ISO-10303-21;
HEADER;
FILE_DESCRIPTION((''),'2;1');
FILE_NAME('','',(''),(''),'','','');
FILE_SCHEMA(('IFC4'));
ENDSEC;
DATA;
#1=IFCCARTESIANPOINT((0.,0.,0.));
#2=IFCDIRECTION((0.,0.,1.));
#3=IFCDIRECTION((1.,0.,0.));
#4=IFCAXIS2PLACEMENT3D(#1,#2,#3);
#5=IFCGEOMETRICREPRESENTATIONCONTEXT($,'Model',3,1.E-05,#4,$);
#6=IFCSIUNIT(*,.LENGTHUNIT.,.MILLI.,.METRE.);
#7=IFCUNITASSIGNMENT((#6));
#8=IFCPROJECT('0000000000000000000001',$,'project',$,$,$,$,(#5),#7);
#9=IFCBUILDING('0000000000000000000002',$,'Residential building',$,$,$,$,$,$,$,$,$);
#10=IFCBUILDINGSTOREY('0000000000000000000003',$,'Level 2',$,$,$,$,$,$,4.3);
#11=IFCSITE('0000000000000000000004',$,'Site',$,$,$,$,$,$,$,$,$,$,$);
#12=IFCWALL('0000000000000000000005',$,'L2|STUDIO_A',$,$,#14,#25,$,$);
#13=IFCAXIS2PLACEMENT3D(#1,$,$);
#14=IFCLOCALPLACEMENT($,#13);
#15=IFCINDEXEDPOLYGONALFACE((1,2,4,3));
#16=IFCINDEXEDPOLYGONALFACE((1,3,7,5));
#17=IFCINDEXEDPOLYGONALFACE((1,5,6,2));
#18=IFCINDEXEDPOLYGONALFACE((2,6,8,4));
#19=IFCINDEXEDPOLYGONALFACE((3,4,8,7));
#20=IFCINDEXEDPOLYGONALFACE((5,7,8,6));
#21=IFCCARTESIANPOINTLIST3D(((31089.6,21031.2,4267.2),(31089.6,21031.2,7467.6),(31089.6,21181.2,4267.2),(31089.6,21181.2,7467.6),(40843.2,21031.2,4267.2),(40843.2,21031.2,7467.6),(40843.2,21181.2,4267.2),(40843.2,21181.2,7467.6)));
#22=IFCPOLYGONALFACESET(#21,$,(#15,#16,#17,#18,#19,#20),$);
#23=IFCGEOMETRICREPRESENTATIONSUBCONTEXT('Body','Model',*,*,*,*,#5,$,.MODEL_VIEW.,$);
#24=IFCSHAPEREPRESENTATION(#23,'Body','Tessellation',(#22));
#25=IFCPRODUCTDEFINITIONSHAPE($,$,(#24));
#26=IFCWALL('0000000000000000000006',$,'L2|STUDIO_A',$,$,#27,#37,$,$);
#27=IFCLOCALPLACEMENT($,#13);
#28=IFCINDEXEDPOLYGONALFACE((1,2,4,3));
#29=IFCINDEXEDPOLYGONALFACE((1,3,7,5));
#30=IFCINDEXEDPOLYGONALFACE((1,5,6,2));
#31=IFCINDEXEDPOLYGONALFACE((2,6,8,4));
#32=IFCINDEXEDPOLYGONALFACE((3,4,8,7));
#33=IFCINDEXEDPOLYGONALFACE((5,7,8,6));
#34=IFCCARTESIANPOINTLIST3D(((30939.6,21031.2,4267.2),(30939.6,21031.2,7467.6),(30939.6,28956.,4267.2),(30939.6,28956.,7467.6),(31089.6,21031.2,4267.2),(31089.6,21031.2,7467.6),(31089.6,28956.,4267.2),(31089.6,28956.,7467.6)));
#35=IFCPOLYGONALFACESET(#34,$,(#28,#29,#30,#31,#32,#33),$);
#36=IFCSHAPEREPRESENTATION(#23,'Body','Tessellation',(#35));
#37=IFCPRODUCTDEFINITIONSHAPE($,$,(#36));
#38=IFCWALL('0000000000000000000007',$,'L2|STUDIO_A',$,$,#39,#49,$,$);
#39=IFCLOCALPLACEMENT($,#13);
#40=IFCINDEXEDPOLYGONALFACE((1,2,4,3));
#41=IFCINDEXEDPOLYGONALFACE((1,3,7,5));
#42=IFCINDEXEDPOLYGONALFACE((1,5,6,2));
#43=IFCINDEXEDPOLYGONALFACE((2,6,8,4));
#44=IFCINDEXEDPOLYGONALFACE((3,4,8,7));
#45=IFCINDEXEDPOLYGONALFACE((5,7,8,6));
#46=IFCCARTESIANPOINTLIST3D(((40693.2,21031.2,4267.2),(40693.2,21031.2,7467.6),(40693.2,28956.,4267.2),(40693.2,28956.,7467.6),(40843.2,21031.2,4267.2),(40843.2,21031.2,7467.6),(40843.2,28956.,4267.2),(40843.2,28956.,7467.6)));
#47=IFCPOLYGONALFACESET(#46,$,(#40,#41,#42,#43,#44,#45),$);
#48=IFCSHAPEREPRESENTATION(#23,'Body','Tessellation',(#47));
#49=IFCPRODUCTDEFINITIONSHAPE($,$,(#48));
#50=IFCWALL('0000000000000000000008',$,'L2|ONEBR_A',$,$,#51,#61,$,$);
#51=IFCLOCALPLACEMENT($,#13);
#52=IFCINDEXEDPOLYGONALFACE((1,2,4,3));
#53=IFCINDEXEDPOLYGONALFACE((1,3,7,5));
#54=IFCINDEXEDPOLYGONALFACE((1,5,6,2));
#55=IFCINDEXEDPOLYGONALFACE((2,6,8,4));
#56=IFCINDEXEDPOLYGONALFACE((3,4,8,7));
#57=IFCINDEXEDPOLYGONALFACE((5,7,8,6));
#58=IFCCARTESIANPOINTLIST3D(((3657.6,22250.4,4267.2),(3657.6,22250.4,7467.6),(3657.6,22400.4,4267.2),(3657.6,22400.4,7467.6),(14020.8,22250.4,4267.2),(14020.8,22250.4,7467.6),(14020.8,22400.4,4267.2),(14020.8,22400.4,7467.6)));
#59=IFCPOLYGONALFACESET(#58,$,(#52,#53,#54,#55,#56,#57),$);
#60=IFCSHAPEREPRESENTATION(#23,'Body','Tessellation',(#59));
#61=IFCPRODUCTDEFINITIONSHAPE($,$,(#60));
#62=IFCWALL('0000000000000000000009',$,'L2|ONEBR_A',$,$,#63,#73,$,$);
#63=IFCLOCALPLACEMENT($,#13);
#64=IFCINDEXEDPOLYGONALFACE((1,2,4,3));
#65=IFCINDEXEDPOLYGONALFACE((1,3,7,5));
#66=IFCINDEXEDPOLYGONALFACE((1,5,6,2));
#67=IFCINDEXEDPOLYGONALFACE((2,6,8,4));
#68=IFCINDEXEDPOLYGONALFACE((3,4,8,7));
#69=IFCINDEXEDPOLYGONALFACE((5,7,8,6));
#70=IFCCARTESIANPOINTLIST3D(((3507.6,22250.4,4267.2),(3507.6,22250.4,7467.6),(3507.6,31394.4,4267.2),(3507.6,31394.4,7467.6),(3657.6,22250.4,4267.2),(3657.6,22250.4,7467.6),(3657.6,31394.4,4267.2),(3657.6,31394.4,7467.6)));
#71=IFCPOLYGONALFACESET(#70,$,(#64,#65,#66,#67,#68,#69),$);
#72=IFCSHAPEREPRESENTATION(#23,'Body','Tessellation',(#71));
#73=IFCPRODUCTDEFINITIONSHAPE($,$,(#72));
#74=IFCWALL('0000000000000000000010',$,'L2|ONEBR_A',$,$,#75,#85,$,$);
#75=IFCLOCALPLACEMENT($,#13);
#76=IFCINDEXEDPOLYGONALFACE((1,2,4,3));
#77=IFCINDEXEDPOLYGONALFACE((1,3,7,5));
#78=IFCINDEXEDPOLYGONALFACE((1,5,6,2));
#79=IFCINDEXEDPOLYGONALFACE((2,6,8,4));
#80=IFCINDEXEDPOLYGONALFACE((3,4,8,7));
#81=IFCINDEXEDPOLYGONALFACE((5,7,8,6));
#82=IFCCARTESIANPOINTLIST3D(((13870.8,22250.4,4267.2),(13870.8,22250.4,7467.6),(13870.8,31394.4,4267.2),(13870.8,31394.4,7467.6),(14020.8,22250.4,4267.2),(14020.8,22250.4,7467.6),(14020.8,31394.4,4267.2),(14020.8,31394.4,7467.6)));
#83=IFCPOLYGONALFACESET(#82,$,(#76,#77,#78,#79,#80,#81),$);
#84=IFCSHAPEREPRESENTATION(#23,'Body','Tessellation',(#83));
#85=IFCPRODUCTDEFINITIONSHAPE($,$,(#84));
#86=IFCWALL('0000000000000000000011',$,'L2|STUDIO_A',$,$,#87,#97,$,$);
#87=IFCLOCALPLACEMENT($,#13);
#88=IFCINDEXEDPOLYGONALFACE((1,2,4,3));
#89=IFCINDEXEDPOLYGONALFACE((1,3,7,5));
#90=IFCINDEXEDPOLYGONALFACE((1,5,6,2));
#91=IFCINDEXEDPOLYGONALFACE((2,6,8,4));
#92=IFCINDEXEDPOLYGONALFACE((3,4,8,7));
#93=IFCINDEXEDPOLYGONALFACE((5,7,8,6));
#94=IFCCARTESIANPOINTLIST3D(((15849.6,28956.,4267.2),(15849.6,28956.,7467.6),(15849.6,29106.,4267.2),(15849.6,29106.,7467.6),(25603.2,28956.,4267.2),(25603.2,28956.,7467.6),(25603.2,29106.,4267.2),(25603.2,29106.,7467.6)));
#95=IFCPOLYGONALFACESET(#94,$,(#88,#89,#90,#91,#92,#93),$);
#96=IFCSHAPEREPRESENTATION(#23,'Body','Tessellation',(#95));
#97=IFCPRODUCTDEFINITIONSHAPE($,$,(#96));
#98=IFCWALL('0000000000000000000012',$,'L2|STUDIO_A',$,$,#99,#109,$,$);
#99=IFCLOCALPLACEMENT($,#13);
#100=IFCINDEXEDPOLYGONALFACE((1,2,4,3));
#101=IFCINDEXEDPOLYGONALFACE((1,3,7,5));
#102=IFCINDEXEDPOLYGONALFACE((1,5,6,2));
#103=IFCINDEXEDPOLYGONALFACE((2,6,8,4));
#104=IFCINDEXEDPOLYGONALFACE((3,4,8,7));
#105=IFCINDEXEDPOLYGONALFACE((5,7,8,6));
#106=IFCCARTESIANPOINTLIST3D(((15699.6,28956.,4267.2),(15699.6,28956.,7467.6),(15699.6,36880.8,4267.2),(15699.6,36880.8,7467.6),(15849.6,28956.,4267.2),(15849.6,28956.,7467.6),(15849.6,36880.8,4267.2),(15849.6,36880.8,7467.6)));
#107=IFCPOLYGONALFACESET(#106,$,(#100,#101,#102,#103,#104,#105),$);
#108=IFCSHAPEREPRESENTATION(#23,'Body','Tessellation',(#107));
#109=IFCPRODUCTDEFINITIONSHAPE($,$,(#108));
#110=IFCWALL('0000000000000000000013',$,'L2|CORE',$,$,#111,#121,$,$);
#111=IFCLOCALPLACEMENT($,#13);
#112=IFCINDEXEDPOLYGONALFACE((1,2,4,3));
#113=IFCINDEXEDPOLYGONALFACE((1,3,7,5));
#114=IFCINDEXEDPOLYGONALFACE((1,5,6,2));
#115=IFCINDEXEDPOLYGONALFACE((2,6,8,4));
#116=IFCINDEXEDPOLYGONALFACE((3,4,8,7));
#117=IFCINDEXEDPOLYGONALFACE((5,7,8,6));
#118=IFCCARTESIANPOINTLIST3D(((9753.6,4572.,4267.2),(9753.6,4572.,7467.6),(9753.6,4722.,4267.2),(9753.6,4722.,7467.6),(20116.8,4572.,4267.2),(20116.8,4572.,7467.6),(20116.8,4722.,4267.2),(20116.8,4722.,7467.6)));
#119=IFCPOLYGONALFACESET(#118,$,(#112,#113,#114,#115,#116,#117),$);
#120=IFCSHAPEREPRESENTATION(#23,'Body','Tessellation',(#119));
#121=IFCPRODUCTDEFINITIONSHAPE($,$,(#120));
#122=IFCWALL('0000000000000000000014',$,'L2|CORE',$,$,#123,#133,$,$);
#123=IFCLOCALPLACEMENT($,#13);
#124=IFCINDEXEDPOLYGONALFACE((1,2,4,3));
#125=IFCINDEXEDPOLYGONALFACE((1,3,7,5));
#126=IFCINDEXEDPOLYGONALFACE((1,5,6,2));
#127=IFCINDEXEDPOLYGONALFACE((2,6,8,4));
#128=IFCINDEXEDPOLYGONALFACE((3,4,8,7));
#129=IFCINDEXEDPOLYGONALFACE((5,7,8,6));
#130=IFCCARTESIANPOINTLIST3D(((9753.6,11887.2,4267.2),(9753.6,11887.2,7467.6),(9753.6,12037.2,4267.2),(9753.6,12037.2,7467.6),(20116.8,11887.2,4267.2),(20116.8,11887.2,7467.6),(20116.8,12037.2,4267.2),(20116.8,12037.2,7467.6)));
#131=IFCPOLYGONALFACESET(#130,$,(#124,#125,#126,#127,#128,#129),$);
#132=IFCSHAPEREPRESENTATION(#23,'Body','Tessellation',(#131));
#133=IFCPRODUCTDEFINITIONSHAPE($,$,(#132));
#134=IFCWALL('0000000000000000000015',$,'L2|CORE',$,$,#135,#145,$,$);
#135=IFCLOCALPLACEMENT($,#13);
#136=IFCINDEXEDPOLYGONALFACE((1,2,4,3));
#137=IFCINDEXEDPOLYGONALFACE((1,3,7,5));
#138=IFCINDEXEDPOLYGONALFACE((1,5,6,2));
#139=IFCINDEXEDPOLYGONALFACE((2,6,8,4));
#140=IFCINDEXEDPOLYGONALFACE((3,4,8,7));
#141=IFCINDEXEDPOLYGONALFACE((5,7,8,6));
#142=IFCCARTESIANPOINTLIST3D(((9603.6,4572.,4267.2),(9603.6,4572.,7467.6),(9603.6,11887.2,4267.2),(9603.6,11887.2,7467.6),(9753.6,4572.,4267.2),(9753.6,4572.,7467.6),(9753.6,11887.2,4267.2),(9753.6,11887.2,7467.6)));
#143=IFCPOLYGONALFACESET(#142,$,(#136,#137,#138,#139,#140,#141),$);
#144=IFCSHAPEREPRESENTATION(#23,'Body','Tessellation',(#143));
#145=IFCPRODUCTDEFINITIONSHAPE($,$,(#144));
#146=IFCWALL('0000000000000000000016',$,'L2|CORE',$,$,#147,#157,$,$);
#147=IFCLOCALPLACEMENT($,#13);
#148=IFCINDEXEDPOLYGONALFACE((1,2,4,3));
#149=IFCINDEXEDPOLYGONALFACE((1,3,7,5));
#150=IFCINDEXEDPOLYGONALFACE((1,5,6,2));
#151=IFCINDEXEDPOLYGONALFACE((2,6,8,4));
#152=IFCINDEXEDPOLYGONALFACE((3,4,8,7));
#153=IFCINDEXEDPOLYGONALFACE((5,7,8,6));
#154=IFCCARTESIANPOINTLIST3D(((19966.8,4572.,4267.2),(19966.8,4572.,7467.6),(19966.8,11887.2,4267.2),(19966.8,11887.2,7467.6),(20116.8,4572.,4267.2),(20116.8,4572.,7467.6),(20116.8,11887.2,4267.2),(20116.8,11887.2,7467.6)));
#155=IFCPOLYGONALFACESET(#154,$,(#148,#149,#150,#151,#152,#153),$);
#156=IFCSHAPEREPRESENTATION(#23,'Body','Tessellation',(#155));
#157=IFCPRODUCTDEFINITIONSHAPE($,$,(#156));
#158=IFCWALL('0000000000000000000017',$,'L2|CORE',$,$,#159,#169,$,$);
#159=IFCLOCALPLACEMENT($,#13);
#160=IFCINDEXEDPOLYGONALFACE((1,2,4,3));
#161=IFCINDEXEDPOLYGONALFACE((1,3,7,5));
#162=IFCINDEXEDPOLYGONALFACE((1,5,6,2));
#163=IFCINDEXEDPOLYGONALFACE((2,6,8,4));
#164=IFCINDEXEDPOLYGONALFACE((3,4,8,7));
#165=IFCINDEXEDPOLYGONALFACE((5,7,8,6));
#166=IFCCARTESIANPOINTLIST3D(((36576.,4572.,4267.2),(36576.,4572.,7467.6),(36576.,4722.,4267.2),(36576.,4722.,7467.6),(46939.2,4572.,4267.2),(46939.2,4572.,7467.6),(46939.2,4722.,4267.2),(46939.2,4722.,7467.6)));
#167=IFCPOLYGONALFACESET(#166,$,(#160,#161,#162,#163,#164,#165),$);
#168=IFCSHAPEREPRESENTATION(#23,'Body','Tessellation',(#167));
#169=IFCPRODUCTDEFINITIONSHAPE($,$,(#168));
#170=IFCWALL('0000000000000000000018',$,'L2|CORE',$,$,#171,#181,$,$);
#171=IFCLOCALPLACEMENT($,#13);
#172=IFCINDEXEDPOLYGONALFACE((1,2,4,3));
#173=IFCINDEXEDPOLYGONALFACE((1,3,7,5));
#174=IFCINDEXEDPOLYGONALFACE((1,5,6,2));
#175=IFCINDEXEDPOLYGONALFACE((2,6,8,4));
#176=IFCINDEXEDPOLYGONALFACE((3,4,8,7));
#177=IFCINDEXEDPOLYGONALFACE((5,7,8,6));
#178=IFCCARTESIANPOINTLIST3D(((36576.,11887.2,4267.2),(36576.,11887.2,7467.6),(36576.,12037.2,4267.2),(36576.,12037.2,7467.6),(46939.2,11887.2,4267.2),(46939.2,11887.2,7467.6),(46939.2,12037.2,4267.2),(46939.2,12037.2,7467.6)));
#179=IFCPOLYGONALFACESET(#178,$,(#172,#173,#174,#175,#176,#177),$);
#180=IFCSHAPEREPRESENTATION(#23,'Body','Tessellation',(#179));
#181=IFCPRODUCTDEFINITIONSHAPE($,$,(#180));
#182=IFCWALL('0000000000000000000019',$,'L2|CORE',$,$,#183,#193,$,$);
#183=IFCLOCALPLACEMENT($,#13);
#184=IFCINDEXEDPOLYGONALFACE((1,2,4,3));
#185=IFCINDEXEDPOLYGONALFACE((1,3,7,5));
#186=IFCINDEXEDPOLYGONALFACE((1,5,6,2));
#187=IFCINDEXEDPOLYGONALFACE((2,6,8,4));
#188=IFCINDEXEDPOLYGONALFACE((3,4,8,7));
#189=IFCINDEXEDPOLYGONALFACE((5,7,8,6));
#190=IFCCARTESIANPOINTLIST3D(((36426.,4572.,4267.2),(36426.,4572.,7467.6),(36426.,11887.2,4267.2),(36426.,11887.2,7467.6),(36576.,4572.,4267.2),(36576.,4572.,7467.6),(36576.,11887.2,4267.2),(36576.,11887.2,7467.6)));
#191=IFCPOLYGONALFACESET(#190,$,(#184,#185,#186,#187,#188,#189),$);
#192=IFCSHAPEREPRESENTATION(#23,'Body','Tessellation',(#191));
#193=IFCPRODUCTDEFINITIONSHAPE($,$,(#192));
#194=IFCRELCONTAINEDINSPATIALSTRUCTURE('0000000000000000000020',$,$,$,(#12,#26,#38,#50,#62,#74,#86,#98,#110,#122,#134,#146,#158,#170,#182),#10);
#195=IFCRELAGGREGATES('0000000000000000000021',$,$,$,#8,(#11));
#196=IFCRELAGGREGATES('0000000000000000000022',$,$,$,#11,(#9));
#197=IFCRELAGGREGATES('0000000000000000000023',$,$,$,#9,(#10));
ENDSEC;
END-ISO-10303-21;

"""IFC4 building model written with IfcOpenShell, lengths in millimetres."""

from ifc_helpers import new_model, si_unit, frame, origin_with_axes, place, context, subcontext, project, spatial, indexed_curve, outline, extrude, element, save


model = new_model("IFC4")

# Units and contexts
model_context = context("Model", 3, precision=1e-05, world=origin_with_axes())
body_context = subcontext(model_context, "Body", "Model", "MODEL_VIEW")
ifc_project = project(units=[si_unit("LENGTHUNIT", "METRE", prefix="MILLI")], contexts=[model_context])

# Site, building, storey
site = spatial("IfcSite", under=ifc_project, Name="Site")
building = spatial("IfcBuilding", under=site, Name="Residential building")
storey = spatial("IfcBuildingStorey", under=building, Name="Level 2", Elevation=4.3)

# Walls
wall_1_placement = place(None, frame((31089.6, 21031.2, 4267.2), z_axis=(0.0, 0.0, 1.0), x_axis=(1.0, 0.0, 0.0)))
element("IfcWall", 1, at=wall_1_placement, inside=storey, Name="L2|STUDIO_A", context=body_context, shape_type="SweptSolid", body=[
    extrude(outline(indexed_curve([(0.0, 0.0), (0.0, 150.0), (9753.6, 150.0), (9753.6, 0.0), (0.0, 0.0)], self_intersect=False)), origin_with_axes(), (0.0, 0.0, 1.0), 3200.4),
])
for number, where, z_axis, x_axis, name in (
    (2, (31089.6, 21031.2, 4267.2), (0.0, 0.0, 1.0), (0.0, 1.0, 0.0), "L2|STUDIO_A"),
    (3, (40843.2, 21031.2, 4267.2), (0.0, 0.0, 1.0), (0.0, 1.0, 0.0), "L2|STUDIO_A"),
):
    element("IfcWall", number, at=place(None, frame(where, z_axis=z_axis, x_axis=x_axis)), inside=storey, Name=name, context=body_context, shape_type="SweptSolid", body=[
        extrude(outline(indexed_curve([(0.0, 0.0), (0.0, 150.0), (7924.8, 150.0), (7924.8, 0.0), (0.0, 0.0)], self_intersect=False)), origin_with_axes(), (0.0, 0.0, 1.0), 3200.4),
    ])
wall_2_placement = place(None, frame((3657.6, 22250.4, 4267.2), z_axis=(0.0, 0.0, 1.0), x_axis=(1.0, 0.0, 0.0)))
element("IfcWall", 4, at=wall_2_placement, inside=storey, Name="L2|ONEBR_A", context=body_context, shape_type="SweptSolid", body=[
    extrude(outline(indexed_curve([(0.0, 0.0), (0.0, 150.0), (10363.2, 150.0), (10363.2, 0.0), (0.0, 0.0)], self_intersect=False)), origin_with_axes(), (0.0, 0.0, 1.0), 3200.4),
])
for number, where, z_axis, x_axis, name in (
    (5, (3657.6, 22250.4, 4267.2), (0.0, 0.0, 1.0), (0.0, 1.0, 0.0), "L2|ONEBR_A"),
    (6, (14020.8, 22250.4, 4267.2), (0.0, 0.0, 1.0), (0.0, 1.0, 0.0), "L2|ONEBR_A"),
):
    element("IfcWall", number, at=place(None, frame(where, z_axis=z_axis, x_axis=x_axis)), inside=storey, Name=name, context=body_context, shape_type="SweptSolid", body=[
        extrude(outline(indexed_curve([(0.0, 0.0), (0.0, 150.0), (9144.0, 150.0), (9144.0, 0.0), (0.0, 0.0)], self_intersect=False)), origin_with_axes(), (0.0, 0.0, 1.0), 3200.4),
    ])
wall_3_placement = place(None, frame((15849.6, 28956.0, 4267.2), z_axis=(0.0, 0.0, 1.0), x_axis=(1.0, 0.0, 0.0)))
element("IfcWall", 7, at=wall_3_placement, inside=storey, Name="L2|STUDIO_A", context=body_context, shape_type="SweptSolid", body=[
    extrude(outline(indexed_curve([(0.0, 0.0), (0.0, 150.0), (9753.6, 150.0), (9753.6, 0.0), (0.0, 0.0)], self_intersect=False)), origin_with_axes(), (0.0, 0.0, 1.0), 3200.4),
])
wall_4_placement = place(None, frame((15849.6, 28956.0, 4267.2), z_axis=(0.0, 0.0, 1.0), x_axis=(0.0, 1.0, 0.0)))
element("IfcWall", 8, at=wall_4_placement, inside=storey, Name="L2|STUDIO_A", context=body_context, shape_type="SweptSolid", body=[
    extrude(outline(indexed_curve([(0.0, 0.0), (0.0, 150.0), (7924.8, 150.0), (7924.8, 0.0), (0.0, 0.0)], self_intersect=False)), origin_with_axes(), (0.0, 0.0, 1.0), 3200.4),
])
for number, where, z_axis, x_axis, name in (
    (9, (9753.6, 4572.0, 4267.2), (0.0, 0.0, 1.0), (1.0, 0.0, 0.0), "L2|CORE"),
    (10, (9753.6, 11887.2, 4267.2), (0.0, 0.0, 1.0), (1.0, 0.0, 0.0), "L2|CORE"),
):
    element("IfcWall", number, at=place(None, frame(where, z_axis=z_axis, x_axis=x_axis)), inside=storey, Name=name, context=body_context, shape_type="SweptSolid", body=[
        extrude(outline(indexed_curve([(0.0, 0.0), (0.0, 150.0), (10363.2, 150.0), (10363.2, 0.0), (0.0, 0.0)], self_intersect=False)), origin_with_axes(), (0.0, 0.0, 1.0), 3200.4),
    ])
for number, where, z_axis, x_axis, name in (
    (11, (9753.6, 4572.0, 4267.2), (0.0, 0.0, 1.0), (0.0, 1.0, 0.0), "L2|CORE"),
    (12, (20116.8, 4572.0, 4267.2), (0.0, 0.0, 1.0), (0.0, 1.0, 0.0), "L2|CORE"),
):
    element("IfcWall", number, at=place(None, frame(where, z_axis=z_axis, x_axis=x_axis)), inside=storey, Name=name, context=body_context, shape_type="SweptSolid", body=[
        extrude(outline(indexed_curve([(0.0, 0.0), (0.0, 150.0), (7315.2, 150.0), (7315.2, 0.0), (0.0, 0.0)], self_intersect=False)), origin_with_axes(), (0.0, 0.0, 1.0), 3200.4),
    ])
for number, where, z_axis, x_axis, name in (
    (13, (36576.0, 4572.0, 4267.2), (0.0, 0.0, 1.0), (1.0, 0.0, 0.0), "L2|CORE"),
    (14, (36576.0, 11887.2, 4267.2), (0.0, 0.0, 1.0), (1.0, 0.0, 0.0), "L2|CORE"),
):
    element("IfcWall", number, at=place(None, frame(where, z_axis=z_axis, x_axis=x_axis)), inside=storey, Name=name, context=body_context, shape_type="SweptSolid", body=[
        extrude(outline(indexed_curve([(0.0, 0.0), (0.0, 150.0), (10363.2, 150.0), (10363.2, 0.0), (0.0, 0.0)], self_intersect=False)), origin_with_axes(), (0.0, 0.0, 1.0), 3200.4),
    ])
wall_5_placement = place(None, frame((36576.0, 4572.0, 4267.2), z_axis=(0.0, 0.0, 1.0), x_axis=(0.0, 1.0, 0.0)))
element("IfcWall", 15, at=wall_5_placement, inside=storey, Name="L2|CORE", context=body_context, shape_type="SweptSolid", body=[
    extrude(outline(indexed_curve([(0.0, 0.0), (0.0, 150.0), (7315.2, 150.0), (7315.2, 0.0), (0.0, 0.0)], self_intersect=False)), origin_with_axes(), (0.0, 0.0, 1.0), 3200.4),
])

save(model, "model.ifc")
